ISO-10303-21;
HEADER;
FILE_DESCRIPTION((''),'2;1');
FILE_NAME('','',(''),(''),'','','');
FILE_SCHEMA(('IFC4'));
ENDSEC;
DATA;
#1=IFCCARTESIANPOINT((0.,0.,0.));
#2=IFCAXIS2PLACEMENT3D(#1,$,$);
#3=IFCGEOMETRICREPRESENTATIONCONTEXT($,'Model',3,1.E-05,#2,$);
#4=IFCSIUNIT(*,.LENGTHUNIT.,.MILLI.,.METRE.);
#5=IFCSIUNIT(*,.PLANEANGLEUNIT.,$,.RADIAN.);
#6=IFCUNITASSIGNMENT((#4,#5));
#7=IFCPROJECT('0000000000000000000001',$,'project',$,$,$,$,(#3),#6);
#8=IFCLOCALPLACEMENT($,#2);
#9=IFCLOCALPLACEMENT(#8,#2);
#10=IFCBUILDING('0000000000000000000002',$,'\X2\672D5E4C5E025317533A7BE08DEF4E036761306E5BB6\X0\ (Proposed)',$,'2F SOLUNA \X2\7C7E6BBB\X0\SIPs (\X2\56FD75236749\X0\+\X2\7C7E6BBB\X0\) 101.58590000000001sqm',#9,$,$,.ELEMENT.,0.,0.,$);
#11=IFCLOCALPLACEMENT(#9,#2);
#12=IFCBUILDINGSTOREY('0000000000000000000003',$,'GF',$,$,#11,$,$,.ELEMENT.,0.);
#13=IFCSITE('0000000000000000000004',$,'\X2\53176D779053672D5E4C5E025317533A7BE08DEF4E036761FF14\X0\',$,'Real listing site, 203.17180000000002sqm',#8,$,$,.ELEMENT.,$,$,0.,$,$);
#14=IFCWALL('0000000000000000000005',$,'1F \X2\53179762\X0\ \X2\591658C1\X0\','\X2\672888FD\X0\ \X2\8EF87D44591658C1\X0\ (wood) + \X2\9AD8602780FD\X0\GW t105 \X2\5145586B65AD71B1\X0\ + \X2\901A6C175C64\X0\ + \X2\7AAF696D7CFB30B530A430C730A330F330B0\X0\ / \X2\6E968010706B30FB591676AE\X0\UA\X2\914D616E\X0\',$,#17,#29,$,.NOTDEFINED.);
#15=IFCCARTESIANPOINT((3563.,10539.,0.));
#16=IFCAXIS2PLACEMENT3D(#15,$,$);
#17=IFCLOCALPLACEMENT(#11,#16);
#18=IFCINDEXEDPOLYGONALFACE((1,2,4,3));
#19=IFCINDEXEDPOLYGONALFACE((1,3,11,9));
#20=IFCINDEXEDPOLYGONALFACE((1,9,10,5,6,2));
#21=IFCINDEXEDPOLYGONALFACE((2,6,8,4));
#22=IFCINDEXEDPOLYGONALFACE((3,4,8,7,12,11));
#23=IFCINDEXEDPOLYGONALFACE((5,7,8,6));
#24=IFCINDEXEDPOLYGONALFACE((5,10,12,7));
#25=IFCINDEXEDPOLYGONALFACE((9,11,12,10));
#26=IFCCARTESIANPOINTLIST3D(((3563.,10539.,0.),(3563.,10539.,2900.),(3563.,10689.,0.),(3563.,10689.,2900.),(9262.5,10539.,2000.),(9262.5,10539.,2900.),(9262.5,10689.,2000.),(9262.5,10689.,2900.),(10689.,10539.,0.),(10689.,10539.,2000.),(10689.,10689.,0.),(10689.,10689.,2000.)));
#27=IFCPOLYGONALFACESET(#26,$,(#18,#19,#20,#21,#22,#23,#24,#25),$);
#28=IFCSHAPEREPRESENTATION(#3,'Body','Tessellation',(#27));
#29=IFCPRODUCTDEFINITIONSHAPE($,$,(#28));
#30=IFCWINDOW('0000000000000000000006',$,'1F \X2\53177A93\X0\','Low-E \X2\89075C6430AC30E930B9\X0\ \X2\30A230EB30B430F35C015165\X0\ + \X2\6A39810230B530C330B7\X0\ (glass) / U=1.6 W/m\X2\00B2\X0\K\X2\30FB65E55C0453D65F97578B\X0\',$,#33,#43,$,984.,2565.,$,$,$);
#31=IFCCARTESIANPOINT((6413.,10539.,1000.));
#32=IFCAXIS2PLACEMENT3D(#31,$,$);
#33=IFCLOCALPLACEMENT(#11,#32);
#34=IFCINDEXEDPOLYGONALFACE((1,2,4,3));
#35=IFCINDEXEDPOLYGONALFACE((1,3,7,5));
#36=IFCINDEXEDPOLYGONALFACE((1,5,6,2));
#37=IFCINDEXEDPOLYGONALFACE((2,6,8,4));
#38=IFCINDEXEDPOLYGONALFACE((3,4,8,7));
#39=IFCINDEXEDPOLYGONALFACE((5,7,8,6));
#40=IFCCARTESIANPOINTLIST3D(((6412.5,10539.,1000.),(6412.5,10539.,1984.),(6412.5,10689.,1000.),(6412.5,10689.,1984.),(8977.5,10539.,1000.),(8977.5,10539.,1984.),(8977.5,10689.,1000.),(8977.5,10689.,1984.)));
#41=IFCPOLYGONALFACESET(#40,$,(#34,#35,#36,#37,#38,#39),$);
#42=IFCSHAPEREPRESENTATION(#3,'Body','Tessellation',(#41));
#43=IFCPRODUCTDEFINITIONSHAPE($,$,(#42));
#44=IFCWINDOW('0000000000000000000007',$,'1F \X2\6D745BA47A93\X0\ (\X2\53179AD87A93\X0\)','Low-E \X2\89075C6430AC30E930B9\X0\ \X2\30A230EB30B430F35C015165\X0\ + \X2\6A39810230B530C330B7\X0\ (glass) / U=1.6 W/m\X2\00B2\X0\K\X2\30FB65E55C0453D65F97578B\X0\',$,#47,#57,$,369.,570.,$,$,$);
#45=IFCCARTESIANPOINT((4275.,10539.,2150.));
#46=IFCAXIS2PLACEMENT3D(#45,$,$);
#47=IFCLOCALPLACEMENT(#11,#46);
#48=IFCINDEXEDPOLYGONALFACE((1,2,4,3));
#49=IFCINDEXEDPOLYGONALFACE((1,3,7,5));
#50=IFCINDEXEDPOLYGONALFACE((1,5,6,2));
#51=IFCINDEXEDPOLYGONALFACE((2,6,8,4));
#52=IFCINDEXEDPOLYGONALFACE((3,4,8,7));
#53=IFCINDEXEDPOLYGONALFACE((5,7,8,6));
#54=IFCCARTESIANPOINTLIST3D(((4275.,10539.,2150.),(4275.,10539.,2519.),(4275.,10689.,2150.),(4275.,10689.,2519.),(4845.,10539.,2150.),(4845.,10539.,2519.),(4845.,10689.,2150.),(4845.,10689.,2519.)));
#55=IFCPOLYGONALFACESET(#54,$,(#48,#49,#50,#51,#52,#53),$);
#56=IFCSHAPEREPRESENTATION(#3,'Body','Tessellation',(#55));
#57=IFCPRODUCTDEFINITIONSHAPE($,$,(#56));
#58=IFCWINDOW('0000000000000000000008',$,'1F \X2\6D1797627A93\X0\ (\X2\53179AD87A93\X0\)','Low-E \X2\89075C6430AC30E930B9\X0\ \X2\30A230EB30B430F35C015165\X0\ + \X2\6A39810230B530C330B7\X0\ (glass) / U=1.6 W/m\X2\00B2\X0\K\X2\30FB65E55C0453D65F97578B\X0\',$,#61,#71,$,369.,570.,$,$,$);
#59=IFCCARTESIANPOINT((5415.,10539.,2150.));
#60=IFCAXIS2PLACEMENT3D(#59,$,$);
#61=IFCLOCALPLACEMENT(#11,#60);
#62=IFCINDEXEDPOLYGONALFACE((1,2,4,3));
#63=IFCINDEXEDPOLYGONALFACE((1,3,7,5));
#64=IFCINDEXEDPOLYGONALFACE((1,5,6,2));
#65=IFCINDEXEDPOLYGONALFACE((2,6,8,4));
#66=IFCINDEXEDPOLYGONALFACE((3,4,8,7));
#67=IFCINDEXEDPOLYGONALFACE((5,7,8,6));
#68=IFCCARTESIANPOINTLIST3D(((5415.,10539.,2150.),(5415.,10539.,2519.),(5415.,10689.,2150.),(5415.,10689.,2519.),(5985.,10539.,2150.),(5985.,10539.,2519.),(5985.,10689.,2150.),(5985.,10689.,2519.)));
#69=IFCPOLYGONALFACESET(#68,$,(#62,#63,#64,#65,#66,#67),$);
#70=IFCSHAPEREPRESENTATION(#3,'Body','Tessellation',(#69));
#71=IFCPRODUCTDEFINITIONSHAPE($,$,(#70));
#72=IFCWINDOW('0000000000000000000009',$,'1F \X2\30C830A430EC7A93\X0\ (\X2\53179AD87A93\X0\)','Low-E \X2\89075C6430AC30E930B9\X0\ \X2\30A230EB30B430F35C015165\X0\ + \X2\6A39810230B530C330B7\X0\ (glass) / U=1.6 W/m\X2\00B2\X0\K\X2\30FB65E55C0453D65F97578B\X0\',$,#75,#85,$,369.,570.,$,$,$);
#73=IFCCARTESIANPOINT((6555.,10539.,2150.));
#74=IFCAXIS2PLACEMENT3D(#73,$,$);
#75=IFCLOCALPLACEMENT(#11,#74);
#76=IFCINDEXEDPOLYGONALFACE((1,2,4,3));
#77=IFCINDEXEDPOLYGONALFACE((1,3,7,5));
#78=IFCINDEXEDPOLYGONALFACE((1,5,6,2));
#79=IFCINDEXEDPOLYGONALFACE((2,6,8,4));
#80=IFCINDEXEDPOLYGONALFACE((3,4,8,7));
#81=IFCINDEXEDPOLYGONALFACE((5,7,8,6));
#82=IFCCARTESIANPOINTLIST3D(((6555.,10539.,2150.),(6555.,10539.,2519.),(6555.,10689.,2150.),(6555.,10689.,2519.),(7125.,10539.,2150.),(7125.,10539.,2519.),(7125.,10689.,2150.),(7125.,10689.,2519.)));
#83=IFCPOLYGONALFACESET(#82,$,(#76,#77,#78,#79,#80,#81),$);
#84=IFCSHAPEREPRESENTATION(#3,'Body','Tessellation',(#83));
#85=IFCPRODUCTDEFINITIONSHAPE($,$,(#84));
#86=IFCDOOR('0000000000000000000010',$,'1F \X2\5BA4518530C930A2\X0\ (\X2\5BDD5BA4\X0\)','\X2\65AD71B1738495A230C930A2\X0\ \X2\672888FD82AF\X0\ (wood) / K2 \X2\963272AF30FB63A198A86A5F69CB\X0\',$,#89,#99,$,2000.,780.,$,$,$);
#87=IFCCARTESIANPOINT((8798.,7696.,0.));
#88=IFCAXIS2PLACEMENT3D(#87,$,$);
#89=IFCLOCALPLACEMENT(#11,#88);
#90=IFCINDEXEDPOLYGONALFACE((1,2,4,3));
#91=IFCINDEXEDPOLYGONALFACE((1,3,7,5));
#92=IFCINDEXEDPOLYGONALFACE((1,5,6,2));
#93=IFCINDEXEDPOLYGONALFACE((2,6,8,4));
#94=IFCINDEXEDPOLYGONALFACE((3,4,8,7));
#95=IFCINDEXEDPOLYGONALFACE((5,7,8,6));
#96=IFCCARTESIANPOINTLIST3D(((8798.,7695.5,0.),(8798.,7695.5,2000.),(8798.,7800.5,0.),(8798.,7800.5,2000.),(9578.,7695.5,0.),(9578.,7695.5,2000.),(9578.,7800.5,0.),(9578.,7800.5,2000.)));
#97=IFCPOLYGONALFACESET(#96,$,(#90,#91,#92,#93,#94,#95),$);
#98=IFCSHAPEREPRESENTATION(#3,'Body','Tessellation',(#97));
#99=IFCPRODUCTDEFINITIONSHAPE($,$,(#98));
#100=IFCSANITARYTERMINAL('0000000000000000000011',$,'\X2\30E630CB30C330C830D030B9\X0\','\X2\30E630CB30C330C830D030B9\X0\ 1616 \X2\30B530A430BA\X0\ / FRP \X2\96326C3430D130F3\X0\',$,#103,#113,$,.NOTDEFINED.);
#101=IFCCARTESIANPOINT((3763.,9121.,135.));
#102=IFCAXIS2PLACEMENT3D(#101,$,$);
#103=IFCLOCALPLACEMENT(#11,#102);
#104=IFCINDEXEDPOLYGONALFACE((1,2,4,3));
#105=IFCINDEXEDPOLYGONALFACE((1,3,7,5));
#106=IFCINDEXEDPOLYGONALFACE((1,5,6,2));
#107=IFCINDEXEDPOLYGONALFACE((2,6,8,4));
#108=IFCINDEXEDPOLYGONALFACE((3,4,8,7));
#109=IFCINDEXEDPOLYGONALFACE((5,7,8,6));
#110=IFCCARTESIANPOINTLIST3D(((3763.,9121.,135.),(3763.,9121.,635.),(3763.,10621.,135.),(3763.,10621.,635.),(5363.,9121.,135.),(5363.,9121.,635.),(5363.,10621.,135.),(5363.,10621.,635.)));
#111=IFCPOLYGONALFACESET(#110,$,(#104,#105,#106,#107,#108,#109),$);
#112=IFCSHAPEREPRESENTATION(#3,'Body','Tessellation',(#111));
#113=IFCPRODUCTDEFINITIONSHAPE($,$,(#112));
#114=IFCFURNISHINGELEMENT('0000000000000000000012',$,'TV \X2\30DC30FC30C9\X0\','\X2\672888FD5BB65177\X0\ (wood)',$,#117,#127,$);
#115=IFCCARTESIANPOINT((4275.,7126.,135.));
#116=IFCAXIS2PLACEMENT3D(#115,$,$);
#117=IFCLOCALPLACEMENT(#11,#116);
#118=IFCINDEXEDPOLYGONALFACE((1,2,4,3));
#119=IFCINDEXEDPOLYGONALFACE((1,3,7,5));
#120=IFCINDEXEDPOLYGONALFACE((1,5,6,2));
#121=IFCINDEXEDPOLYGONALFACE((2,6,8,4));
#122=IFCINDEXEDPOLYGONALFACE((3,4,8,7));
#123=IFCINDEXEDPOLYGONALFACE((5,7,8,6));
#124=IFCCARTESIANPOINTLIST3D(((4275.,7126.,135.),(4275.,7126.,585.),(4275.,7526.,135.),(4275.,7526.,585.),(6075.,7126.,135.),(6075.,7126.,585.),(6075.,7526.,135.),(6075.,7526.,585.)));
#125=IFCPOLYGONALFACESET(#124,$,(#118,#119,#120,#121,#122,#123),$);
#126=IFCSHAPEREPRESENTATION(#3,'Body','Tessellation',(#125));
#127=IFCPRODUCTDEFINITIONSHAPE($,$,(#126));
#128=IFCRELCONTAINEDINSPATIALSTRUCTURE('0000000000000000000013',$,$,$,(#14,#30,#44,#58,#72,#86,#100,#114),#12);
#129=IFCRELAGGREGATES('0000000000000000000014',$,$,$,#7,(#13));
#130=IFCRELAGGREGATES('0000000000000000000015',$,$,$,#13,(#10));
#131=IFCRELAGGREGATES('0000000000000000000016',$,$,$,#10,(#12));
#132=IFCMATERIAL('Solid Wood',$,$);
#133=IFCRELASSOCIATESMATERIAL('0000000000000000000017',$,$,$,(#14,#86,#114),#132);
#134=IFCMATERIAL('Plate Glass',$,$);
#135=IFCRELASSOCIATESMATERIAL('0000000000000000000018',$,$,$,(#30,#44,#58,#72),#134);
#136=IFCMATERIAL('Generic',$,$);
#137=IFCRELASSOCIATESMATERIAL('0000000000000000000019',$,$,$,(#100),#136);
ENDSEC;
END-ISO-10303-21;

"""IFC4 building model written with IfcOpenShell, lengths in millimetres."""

from ifc_helpers import new_model, si_unit, frame, frame_2d, origin, place, context, project, spatial, rectangle, extrude, material, element, fill, save


model = new_model("IFC4")

# Units and contexts
model_context = context("Model", 3, precision=1e-05, world=origin())
ifc_project = project(units=[si_unit("LENGTHUNIT", "METRE", prefix="MILLI"), si_unit("PLANEANGLEUNIT", "RADIAN")], contexts=[model_context])

# Site, building, storey
site_placement = place(None, origin())
site = spatial("IfcSite", under=ifc_project, at=site_placement, Name="北海道札幌市北区篠路七条４", ObjectType="Real listing site, 203.17180000000002sqm", CompositionType="ELEMENT", RefElevation=0.0)
building_placement = place(site_placement, origin())
building = spatial("IfcBuilding", under=site, at=building_placement, Name="札幌市北区篠路七条の家 (Proposed)", ObjectType="2F SOLUNA 籾殻SIPs (国産杉+籾殻) 101.58590000000001sqm", CompositionType="ELEMENT", ElevationOfRefHeight=0.0, ElevationOfTerrain=0.0)
storey_placement = place(building_placement, origin())
storey = spatial("IfcBuildingStorey", under=building, at=storey_placement, Name="GF", CompositionType="ELEMENT", Elevation=0.0)

# Wall, openings, windows
ifc_material_1 = material(Name="Solid Wood")
wall_1_placement = place(storey_placement, frame((3563.0, 10539.0, 0.0)))
wall_1 = element("IfcWall", 1, at=wall_1_placement, inside=storey, material=ifc_material_1, Name="1F 北面 外壁", Description="木製 軸組外壁 (wood) + 高性能GW t105 充填断熱 + 通気層 + 窯業系サイディング / 準耐火・外皮UA配慮", PredefinedType="NOTDEFINED", context=model_context, shape_type="SweptSolid", body=[
    extrude(rectangle(XDim=7126.0, YDim=150.0, at=frame_2d((3563.0, 75.0))), frame((3563.0, 10539.0, 0.0)), (0.0, 0.0, 1.0), 2900.0),
])
opening_1_placement = place(storey_placement, frame((6413.0, 10539.0, 1000.0)))
opening_1 = element("IfcOpeningElement", 2, at=opening_1_placement, cuts=wall_1, PredefinedType="NOTDEFINED", context=model_context, shape_type="SweptSolid", body=[
    extrude(rectangle(XDim=2565.0, YDim=150.0, at=frame_2d((1282.0, 75.0))), frame((6413.0, 10539.0, 1000.0)), (0.0, 0.0, 1.0), 984.0),
])
opening_2_placement = place(storey_placement, frame((4275.0, 10539.0, 2150.0)))
opening_2 = element("IfcOpeningElement", 3, at=opening_2_placement, cuts=wall_1, PredefinedType="NOTDEFINED", context=model_context, shape_type="SweptSolid", body=[
    extrude(rectangle(XDim=570.0, YDim=150.0, at=frame_2d((285.0, 75.0))), frame((4275.0, 10539.0, 2150.0)), (0.0, 0.0, 1.0), 369.0),
])
opening_3_placement = place(storey_placement, frame((5415.0, 10539.0, 2150.0)))
opening_3 = element("IfcOpeningElement", 4, at=opening_3_placement, cuts=wall_1, PredefinedType="NOTDEFINED", context=model_context, shape_type="SweptSolid", body=[
    extrude(rectangle(XDim=570.0, YDim=150.0, at=frame_2d((285.0, 75.0))), frame((5415.0, 10539.0, 2150.0)), (0.0, 0.0, 1.0), 369.0),
])
opening_4_placement = place(storey_placement, frame((6555.0, 10539.0, 2150.0)))
opening_4 = element("IfcOpeningElement", 5, at=opening_4_placement, cuts=wall_1, PredefinedType="NOTDEFINED", context=model_context, shape_type="SweptSolid", body=[
    extrude(rectangle(XDim=570.0, YDim=150.0, at=frame_2d((285.0, 75.0))), frame((6555.0, 10539.0, 2150.0)), (0.0, 0.0, 1.0), 369.0),
])
ifc_material_2 = material(Name="Plate Glass")
window_1_placement = place(storey_placement, frame((6413.0, 10539.0, 1000.0)))
window_1 = element("IfcWindow", 6, at=window_1_placement, inside=storey, material=ifc_material_2, Name="1F 北窓", Description="Low-E 複層ガラス アルゴン封入 + 樹脂サッシ (glass) / U=1.6 W/m²K・日射取得型", OverallHeight=984.0, OverallWidth=2565.0, context=model_context, shape_type="SweptSolid", body=[
    extrude(rectangle(XDim=2565.0, YDim=150.0, at=frame_2d((1282.0, 75.0))), frame((6413.0, 10539.0, 1000.0)), (0.0, 0.0, 1.0), 984.0),
])
fill(opening_1, window_1)
window_2_placement = place(storey_placement, frame((4275.0, 10539.0, 2150.0)))
window_2 = element("IfcWindow", 7, at=window_2_placement, inside=storey, material=ifc_material_2, Name="1F 浴室窓 (北高窓)", Description="Low-E 複層ガラス アルゴン封入 + 樹脂サッシ (glass) / U=1.6 W/m²K・日射取得型", OverallHeight=369.0, OverallWidth=570.0, context=model_context, shape_type="SweptSolid", body=[
    extrude(rectangle(XDim=570.0, YDim=150.0, at=frame_2d((285.0, 75.0))), frame((4275.0, 10539.0, 2150.0)), (0.0, 0.0, 1.0), 369.0),
])
fill(opening_2, window_2)
window_3_placement = place(storey_placement, frame((5415.0, 10539.0, 2150.0)))
window_3 = element("IfcWindow", 8, at=window_3_placement, inside=storey, material=ifc_material_2, Name="1F 洗面窓 (北高窓)", Description="Low-E 複層ガラス アルゴン封入 + 樹脂サッシ (glass) / U=1.6 W/m²K・日射取得型", OverallHeight=369.0, OverallWidth=570.0, context=model_context, shape_type="SweptSolid", body=[
    extrude(rectangle(XDim=570.0, YDim=150.0, at=frame_2d((285.0, 75.0))), frame((5415.0, 10539.0, 2150.0)), (0.0, 0.0, 1.0), 369.0),
])
fill(opening_3, window_3)
window_4_placement = place(storey_placement, frame((6555.0, 10539.0, 2150.0)))
window_4 = element("IfcWindow", 9, at=window_4_placement, inside=storey, material=ifc_material_2, Name="1F トイレ窓 (北高窓)", Description="Low-E 複層ガラス アルゴン封入 + 樹脂サッシ (glass) / U=1.6 W/m²K・日射取得型", OverallHeight=369.0, OverallWidth=570.0, context=model_context, shape_type="SweptSolid", body=[
    extrude(rectangle(XDim=570.0, YDim=150.0, at=frame_2d((285.0, 75.0))), frame((6555.0, 10539.0, 2150.0)), (0.0, 0.0, 1.0), 369.0),
])
fill(opening_4, window_4)

# Door
door_1_placement = place(storey_placement, frame((8798.0, 7696.0, 0.0)))
element("IfcDoor", 10, at=door_1_placement, inside=storey, material=ifc_material_1, Name="1F 室内ドア (寝室)", Description="断熱玄関ドア 木製芯 (wood) / K2 防犯・採風機構", OverallHeight=2000.0, OverallWidth=780.0, context=model_context, shape_type="SweptSolid", body=[
    extrude(rectangle(XDim=780.0, YDim=105.0, at=frame_2d((390.0, 52.0))), frame((8798.0, 7696.0, 0.0)), (0.0, 0.0, 1.0), 2000.0),
])

# Sanitary terminal
ifc_material_3 = material(Name="Generic")
sanitary_terminal_placement = place(storey_placement, frame((3763.0, 9121.0, 135.0)))
element("IfcSanitaryTerminal", 11, at=sanitary_terminal_placement, inside=storey, material=ifc_material_3, Name="ユニットバス", Description="ユニットバス 1616 サイズ / FRP 防水パン", PredefinedType="NOTDEFINED", context=model_context, shape_type="SweptSolid", body=[
    extrude(rectangle(XDim=1600.0, YDim=1500.0, at=frame_2d((800.0, 750.0))), frame((3763.0, 9121.0, 135.0)), (0.0, 0.0, 1.0), 500.0),
])

# Furnishing element
furnishing_placement = place(storey_placement, frame((4275.0, 7126.0, 135.0)))
element("IfcFurnishingElement", 12, at=furnishing_placement, inside=storey, material=ifc_material_1, Name="TV ボード", Description="木製家具 (wood)", context=model_context, shape_type="SweptSolid", body=[
    extrude(rectangle(XDim=1800.0, YDim=400.0, at=frame_2d((900.0, 200.0))), frame((4275.0, 7126.0, 135.0)), (0.0, 0.0, 1.0), 450.0),
])

save(model, "model.ifc")
